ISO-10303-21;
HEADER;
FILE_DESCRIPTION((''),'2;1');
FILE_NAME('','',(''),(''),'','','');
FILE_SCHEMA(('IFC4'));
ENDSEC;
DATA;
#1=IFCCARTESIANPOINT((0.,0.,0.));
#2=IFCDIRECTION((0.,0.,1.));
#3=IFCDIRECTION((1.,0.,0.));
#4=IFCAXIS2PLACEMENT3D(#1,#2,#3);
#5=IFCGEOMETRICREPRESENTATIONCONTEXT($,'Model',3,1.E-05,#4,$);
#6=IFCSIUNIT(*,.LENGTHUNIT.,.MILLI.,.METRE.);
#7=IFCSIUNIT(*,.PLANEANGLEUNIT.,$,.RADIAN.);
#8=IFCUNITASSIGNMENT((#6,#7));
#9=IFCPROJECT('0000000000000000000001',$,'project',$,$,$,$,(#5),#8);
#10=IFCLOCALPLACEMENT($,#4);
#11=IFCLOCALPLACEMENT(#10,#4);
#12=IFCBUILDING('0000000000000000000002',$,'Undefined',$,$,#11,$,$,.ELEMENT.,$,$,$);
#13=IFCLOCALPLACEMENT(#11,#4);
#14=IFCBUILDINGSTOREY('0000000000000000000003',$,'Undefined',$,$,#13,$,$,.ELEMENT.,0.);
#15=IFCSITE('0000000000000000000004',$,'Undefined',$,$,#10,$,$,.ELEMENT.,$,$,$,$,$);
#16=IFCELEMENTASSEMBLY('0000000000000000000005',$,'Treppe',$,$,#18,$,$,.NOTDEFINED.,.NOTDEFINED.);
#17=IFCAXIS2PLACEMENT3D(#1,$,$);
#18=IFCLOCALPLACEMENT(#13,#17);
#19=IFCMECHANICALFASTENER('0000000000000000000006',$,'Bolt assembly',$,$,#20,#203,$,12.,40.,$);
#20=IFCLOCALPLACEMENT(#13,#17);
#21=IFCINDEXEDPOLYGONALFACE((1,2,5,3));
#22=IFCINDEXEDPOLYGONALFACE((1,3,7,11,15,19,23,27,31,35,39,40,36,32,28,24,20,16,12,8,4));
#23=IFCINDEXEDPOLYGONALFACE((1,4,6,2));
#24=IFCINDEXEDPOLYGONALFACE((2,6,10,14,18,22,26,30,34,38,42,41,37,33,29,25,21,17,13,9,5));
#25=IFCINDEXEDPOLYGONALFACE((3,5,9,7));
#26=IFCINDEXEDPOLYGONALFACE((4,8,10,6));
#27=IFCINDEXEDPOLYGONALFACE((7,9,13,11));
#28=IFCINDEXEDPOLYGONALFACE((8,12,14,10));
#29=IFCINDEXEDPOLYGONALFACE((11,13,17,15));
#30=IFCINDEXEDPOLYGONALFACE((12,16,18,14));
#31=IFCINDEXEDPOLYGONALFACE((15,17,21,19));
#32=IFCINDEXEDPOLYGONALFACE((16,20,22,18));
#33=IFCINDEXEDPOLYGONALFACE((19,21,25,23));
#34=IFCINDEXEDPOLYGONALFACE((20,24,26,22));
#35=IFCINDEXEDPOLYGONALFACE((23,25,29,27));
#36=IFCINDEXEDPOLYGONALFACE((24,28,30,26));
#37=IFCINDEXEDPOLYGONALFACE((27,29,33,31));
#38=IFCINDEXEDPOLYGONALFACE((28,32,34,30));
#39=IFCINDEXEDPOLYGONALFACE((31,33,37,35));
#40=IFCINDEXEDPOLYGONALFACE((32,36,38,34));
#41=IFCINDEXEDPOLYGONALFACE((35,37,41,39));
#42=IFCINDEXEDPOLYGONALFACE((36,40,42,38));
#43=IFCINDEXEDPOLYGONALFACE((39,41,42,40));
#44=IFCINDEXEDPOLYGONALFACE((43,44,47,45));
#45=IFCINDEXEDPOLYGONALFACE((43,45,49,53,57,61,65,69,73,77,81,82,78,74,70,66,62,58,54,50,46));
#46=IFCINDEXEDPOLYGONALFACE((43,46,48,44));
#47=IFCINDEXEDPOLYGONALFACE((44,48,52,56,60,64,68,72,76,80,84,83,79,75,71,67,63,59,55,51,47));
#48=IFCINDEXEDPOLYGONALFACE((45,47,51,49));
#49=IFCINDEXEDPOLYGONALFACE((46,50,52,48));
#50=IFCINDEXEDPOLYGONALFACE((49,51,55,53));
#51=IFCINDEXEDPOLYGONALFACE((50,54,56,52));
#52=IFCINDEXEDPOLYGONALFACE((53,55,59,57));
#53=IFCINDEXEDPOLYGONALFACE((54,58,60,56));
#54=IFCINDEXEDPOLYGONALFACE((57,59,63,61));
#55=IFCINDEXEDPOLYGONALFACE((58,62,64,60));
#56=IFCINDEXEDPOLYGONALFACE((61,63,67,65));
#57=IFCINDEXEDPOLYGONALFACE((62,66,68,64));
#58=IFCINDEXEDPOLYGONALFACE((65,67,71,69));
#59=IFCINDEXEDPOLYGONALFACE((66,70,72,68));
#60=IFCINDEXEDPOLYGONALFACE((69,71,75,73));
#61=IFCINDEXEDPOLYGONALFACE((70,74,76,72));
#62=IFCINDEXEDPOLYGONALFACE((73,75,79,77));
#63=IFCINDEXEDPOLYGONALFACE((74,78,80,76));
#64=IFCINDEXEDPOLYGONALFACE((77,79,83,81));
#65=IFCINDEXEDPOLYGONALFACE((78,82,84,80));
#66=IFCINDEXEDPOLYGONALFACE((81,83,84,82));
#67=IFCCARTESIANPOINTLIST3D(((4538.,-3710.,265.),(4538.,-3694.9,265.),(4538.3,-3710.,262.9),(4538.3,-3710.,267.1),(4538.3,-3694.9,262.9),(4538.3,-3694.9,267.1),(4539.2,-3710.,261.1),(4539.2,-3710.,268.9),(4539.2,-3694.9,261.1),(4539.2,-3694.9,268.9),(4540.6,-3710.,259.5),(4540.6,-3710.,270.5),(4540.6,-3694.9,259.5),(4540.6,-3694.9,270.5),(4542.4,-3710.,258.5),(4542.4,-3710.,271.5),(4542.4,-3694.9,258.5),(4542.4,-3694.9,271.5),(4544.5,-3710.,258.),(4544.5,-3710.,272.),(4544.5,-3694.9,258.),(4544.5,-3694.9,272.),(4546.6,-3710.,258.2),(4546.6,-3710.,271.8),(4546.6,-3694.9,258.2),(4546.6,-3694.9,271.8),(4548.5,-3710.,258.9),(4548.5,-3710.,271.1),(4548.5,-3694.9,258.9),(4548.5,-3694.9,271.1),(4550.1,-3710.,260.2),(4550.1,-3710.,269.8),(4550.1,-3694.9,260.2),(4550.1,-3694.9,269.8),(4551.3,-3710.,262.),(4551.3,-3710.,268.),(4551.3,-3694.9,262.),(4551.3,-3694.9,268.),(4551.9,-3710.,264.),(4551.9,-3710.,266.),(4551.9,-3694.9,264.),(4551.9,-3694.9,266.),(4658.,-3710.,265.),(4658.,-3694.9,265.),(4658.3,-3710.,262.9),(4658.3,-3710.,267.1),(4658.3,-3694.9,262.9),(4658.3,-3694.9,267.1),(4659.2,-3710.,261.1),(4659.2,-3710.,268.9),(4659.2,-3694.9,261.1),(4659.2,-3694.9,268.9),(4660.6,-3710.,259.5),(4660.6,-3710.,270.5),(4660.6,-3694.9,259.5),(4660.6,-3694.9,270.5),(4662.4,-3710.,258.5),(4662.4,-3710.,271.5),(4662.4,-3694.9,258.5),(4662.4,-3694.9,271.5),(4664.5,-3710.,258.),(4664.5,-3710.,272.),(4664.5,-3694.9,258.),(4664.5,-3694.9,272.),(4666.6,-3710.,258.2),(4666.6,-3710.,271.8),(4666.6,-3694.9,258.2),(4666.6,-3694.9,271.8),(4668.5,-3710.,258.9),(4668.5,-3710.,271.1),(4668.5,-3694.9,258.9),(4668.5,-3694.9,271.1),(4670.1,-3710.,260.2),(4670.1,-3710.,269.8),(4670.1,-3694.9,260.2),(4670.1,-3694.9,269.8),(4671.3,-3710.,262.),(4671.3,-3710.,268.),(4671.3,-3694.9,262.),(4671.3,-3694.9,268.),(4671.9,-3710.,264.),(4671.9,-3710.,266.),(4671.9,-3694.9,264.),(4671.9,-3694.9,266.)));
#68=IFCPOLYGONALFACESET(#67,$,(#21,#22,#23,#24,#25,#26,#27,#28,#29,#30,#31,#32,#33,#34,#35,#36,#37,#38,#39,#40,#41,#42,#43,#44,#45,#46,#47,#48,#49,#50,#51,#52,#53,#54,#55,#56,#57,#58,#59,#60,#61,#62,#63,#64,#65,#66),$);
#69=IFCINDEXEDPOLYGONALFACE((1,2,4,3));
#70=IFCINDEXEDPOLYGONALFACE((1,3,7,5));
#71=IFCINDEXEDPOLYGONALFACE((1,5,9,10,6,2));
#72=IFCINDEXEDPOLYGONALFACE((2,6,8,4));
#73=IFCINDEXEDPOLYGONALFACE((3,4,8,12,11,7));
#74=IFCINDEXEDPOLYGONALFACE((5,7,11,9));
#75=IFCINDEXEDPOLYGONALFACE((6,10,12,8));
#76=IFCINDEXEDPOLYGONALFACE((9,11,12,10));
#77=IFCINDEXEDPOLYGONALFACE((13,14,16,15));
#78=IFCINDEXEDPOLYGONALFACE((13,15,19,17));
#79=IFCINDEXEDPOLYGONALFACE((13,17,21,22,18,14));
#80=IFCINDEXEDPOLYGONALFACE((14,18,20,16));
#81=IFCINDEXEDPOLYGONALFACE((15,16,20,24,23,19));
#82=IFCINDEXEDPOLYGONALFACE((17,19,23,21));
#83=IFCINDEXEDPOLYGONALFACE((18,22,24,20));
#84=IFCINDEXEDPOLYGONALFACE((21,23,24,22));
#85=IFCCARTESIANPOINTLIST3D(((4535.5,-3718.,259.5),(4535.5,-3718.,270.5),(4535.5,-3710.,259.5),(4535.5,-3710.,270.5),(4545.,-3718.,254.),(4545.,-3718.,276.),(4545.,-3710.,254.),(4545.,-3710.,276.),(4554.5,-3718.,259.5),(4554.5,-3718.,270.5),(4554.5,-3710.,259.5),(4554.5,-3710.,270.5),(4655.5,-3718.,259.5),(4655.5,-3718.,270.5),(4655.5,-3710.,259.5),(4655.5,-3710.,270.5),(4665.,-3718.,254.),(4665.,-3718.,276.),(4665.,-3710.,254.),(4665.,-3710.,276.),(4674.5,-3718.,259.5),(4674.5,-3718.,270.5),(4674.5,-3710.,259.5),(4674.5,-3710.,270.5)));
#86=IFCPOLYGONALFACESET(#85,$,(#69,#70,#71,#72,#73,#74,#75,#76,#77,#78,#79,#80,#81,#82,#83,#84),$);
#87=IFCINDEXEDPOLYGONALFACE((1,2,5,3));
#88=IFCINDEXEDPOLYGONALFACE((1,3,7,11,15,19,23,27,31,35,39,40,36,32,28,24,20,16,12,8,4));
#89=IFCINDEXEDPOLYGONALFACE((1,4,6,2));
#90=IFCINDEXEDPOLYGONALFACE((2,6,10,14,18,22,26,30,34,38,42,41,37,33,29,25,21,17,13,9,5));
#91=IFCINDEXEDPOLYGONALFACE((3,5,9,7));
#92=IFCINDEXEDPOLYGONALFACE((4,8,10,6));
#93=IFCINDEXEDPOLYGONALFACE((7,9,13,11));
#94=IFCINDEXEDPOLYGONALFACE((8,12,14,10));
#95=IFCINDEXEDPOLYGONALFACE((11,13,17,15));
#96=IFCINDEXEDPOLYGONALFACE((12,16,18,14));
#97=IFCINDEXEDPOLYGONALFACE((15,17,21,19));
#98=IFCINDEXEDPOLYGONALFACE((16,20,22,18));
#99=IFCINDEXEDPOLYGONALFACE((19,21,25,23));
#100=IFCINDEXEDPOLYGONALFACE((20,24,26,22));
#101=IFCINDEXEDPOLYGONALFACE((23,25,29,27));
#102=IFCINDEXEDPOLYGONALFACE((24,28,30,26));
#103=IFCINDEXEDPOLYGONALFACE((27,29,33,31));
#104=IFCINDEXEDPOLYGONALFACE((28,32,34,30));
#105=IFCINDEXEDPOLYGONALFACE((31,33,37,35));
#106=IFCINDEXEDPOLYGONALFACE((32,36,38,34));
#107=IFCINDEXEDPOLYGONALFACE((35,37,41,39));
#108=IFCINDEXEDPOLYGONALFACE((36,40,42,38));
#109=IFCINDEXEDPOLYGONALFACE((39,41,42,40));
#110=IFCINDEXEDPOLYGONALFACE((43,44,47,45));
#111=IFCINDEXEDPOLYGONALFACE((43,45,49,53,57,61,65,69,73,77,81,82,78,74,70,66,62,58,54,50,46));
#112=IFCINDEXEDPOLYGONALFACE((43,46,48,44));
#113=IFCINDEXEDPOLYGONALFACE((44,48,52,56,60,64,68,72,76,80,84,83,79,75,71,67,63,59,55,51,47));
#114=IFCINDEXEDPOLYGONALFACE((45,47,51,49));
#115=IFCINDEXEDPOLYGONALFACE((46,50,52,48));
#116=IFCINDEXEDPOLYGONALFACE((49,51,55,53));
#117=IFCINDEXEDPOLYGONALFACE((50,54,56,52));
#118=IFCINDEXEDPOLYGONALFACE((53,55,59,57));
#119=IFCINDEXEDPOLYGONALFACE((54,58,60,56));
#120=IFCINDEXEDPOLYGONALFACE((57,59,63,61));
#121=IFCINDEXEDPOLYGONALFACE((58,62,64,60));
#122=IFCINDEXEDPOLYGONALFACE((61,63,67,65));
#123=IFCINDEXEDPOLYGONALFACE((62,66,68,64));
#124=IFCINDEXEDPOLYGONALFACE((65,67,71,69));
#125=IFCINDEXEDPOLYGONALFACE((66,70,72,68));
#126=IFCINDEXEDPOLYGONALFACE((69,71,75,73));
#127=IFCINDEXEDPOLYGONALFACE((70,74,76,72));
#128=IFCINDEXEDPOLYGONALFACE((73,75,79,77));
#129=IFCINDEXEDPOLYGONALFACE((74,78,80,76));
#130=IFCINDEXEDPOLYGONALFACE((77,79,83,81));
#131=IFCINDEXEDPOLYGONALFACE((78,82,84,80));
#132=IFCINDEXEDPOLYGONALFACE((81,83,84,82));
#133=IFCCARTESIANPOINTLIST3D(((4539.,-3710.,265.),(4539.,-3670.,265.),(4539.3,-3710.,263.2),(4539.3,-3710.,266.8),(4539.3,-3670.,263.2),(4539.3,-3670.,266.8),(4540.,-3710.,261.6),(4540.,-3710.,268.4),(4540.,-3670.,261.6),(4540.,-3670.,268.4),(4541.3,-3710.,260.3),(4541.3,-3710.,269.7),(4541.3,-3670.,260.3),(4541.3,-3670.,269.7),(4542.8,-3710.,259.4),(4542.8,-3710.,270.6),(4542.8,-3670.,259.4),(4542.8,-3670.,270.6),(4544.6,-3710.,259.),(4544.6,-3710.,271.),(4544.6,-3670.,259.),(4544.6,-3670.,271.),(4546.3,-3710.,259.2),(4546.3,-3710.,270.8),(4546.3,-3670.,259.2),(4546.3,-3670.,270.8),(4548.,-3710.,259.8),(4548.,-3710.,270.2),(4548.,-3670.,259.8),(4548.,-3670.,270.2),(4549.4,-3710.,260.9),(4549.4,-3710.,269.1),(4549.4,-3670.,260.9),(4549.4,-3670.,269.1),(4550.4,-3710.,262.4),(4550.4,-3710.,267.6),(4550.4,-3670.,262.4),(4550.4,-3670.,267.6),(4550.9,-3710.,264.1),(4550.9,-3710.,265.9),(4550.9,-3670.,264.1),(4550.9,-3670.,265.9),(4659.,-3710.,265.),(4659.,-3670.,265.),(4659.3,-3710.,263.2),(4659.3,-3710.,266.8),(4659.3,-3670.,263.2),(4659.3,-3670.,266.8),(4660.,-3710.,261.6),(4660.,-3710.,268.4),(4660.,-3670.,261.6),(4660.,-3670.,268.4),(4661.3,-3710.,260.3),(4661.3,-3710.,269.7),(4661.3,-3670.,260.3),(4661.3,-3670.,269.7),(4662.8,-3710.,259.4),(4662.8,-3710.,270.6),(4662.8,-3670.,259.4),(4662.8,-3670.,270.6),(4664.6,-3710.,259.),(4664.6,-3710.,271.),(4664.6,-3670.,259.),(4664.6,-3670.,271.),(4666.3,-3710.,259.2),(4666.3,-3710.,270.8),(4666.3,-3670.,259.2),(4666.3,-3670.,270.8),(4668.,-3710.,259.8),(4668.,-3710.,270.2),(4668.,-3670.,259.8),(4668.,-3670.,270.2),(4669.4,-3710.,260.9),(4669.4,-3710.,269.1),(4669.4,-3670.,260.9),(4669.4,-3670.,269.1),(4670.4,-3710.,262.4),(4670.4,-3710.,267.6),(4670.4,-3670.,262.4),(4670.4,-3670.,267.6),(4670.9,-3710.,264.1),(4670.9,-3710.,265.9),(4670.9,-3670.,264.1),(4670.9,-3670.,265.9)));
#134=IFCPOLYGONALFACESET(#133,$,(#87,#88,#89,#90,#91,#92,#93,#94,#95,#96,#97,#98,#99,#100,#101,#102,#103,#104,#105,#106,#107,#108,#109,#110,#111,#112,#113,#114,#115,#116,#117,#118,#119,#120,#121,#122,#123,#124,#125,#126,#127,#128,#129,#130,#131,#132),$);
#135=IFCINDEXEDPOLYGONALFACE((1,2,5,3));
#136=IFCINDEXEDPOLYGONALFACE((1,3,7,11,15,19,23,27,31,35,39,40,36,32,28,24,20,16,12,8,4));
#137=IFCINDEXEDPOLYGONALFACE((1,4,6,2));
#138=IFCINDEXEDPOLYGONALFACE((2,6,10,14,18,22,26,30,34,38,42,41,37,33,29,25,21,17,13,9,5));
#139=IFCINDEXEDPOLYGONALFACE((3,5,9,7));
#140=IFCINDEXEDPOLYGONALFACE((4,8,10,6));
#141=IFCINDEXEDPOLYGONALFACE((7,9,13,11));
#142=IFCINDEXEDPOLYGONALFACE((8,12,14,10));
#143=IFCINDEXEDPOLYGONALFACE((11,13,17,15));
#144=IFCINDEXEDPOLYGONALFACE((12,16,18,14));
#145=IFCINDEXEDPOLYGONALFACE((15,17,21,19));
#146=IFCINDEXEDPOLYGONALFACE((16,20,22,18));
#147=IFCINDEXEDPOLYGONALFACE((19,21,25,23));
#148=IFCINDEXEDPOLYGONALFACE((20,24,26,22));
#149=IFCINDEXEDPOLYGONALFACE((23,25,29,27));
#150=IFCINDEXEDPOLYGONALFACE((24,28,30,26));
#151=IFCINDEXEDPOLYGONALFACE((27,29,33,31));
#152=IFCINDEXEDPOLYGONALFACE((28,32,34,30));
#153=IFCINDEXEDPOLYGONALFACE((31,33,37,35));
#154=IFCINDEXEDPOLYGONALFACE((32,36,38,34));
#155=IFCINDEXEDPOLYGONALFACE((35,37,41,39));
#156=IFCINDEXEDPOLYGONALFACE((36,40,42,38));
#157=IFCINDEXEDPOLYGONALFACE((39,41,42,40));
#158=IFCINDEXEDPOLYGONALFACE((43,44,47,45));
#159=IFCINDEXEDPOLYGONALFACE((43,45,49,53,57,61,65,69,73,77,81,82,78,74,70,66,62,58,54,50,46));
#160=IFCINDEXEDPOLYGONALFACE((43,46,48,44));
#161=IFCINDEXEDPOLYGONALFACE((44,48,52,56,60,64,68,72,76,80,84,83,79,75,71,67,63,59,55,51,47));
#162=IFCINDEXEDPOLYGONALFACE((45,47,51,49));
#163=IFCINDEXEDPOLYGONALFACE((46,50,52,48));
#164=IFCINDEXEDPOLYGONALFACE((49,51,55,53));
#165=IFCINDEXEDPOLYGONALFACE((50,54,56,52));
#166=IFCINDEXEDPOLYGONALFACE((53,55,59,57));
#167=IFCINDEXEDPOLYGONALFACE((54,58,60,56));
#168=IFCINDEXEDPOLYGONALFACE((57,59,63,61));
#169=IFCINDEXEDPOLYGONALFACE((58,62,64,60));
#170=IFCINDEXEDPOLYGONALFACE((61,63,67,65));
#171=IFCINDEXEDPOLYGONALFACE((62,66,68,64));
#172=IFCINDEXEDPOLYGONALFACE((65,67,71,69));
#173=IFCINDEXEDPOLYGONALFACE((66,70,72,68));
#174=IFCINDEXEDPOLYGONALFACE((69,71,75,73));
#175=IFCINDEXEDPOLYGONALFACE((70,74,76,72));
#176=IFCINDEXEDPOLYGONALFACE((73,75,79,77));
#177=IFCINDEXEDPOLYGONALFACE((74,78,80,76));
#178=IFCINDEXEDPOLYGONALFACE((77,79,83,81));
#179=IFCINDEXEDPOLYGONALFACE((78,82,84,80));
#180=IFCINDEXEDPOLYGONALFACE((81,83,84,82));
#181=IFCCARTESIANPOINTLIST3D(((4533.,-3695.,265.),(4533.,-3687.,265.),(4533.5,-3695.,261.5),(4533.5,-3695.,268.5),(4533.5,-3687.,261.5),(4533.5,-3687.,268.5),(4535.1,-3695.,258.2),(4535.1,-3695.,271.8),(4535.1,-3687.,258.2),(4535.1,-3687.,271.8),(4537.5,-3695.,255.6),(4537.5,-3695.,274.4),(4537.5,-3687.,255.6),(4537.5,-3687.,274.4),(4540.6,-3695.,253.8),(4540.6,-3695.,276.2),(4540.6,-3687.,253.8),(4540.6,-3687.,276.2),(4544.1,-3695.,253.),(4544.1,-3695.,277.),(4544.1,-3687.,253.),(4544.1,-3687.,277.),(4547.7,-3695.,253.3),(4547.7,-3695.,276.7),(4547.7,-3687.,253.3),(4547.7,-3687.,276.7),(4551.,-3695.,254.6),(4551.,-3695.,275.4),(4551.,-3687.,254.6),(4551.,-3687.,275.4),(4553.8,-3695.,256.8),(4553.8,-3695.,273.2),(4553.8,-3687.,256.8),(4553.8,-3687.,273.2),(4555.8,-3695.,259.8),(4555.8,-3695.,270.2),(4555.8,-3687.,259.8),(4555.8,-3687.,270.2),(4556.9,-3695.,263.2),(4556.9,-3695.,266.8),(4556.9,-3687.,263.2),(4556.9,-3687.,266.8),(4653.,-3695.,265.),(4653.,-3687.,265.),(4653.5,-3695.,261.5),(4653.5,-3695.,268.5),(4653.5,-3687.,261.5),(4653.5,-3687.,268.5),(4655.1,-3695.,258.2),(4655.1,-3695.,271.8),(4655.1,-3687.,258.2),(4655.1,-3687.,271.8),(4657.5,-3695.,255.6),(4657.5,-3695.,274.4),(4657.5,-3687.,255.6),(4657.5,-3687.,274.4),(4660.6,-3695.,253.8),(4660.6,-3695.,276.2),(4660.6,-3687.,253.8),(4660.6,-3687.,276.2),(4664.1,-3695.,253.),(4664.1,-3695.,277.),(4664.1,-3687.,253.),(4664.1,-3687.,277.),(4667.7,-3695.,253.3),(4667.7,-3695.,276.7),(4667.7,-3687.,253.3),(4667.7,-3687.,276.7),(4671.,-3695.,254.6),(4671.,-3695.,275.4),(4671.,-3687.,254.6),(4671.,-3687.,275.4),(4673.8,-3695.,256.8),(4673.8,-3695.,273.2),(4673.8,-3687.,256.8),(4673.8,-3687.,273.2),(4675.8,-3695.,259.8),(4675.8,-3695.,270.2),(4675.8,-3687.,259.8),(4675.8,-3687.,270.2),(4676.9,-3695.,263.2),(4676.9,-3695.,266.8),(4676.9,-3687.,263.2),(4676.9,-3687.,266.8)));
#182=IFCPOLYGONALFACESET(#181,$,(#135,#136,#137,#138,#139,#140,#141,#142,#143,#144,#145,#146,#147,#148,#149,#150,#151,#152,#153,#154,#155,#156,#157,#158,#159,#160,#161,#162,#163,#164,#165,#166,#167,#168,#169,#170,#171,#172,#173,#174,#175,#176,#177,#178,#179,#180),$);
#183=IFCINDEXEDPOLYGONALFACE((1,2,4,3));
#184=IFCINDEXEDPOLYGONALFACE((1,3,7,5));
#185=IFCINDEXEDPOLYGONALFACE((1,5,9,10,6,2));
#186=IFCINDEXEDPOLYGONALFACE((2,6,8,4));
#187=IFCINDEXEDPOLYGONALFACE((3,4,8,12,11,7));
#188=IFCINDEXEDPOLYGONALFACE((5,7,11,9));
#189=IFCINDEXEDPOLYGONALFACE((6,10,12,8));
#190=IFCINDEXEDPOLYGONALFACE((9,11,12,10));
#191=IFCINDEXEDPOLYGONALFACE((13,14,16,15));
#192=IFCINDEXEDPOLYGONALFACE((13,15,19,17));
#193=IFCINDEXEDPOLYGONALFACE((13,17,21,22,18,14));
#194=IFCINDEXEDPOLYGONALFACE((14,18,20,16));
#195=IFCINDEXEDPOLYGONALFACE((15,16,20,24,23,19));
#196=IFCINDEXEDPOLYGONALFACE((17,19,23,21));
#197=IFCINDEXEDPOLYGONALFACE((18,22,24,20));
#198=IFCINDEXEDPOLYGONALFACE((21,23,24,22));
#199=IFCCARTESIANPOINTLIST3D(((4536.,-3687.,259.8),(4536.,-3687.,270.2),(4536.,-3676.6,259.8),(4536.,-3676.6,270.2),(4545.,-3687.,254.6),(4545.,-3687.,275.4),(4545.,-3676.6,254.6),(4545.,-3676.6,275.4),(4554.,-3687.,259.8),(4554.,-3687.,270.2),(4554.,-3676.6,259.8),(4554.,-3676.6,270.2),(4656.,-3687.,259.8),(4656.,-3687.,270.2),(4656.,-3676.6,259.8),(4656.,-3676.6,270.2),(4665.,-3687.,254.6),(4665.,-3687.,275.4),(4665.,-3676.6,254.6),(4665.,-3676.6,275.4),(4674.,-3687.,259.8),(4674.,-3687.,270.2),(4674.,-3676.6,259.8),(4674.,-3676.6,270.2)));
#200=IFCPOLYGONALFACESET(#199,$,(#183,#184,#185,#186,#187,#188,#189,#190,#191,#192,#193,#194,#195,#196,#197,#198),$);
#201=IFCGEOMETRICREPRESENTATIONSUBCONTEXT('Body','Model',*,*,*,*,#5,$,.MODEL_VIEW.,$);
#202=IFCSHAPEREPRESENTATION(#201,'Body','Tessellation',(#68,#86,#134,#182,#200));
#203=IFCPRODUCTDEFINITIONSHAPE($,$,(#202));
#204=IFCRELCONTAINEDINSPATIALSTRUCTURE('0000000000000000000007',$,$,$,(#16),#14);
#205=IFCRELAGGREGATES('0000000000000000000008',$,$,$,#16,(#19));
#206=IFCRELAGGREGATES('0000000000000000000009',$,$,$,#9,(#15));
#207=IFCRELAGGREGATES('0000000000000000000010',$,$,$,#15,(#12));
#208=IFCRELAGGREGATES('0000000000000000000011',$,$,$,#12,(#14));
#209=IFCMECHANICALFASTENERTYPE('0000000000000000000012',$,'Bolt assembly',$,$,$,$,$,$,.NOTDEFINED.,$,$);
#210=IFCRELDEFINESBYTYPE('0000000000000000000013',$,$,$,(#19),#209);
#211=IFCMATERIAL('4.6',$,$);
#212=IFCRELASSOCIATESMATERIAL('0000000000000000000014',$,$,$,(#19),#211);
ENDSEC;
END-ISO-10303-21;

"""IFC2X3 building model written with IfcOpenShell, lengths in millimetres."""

from ifc_helpers import new_model, si_unit, frame, origin_with_axes, origin_2d_with_axis, place, context, subcontext, project, spatial, polyline, circle, outline, extrude, source, transform, mapped, material, type_object, element, aggregate, save


model = new_model("IFC2X3")

# Units and contexts
model_context = context("Model", 3, precision=1e-05, world=origin_with_axes())
body_context = subcontext(model_context, "Body", "Model", "MODEL_VIEW")
ifc_project = project(units=[si_unit("LENGTHUNIT", "METRE", prefix="MILLI"), si_unit("PLANEANGLEUNIT", "RADIAN")], contexts=[model_context])

# Site, building, storey
site_placement = place(None, origin_with_axes())
site = spatial("IfcSite", under=ifc_project, at=site_placement, Name="Undefined", CompositionType="ELEMENT")
building_placement = place(site_placement, origin_with_axes())
building = spatial("IfcBuilding", under=site, at=building_placement, Name="Undefined", CompositionType="ELEMENT")
storey_placement = place(building_placement, origin_with_axes())
storey = spatial("IfcBuildingStorey", under=building, at=storey_placement, Name="Undefined", CompositionType="ELEMENT", Elevation=0.0)

# Element assembly
assembly_1_placement = place(storey_placement, origin_with_axes())
assembly_1 = element("IfcElementAssembly", 1, at=assembly_1_placement, inside=storey, Name="Treppe", AssemblyPlace="NOTDEFINED", PredefinedType="NOTDEFINED")

# Mechanical fastener
ifc_material_1 = material(Name="4.6")
mechanical_fastener_type = type_object("IfcMechanicalFastenerType", Name="Bolt assembly")
shared_shape_1 = source(origin_with_axes(), body_context, "Body", "SweptSolid", [
    extrude(circle(Radius=7.0, at=origin_2d_with_axis()), frame((0.0, 0.0, 0.0), z_axis=(0.0, 1.0, 0.0), x_axis=(1.0, 0.0, 0.0)), (0.0, 0.0, 1.0), 15.1),
    extrude(outline(polyline([(9.5, -5.5), (9.5, 5.5), (0.0, 11.0), (-9.5, 5.5), (-9.5, -5.5), (0.0, -11.0), (9.5, -5.5)])), frame((0.0, -8.0, 0.0), z_axis=(0.0, 1.0, 0.0), x_axis=(1.0, 0.0, 0.0)), (0.0, 0.0, 1.0), 8.0),
    extrude(circle(Radius=6.0, at=origin_2d_with_axis()), frame((0.0, 0.0, 0.0), z_axis=(0.0, 1.0, 0.0), x_axis=(1.0, 0.0, 0.0)), (0.0, 0.0, 1.0), 40.0),
    extrude(circle(Radius=12.0, at=origin_2d_with_axis()), frame((0.0, 15.0, 0.0), z_axis=(0.0, 1.0, 0.0), x_axis=(1.0, 0.0, 0.0)), (0.0, 0.0, 1.0), 8.0),
    extrude(outline(polyline([(9.0, -5.2), (9.0, 5.2), (0.0, 10.4), (-9.0, 5.2), (-9.0, -5.2), (0.0, -10.4), (9.0, -5.2)])), frame((0.0, 23.0, 0.0), z_axis=(0.0, 1.0, 0.0), x_axis=(1.0, 0.0, 0.0)), (0.0, 0.0, 1.0), 10.4),
])
mechanical_fastener_1_placement = place(assembly_1_placement, frame((4665.0, -3710.0, 265.0), z_axis=(0.0, 0.0, -1.0), x_axis=(-1.0, 0.0, 0.0)))
mechanical_fastener_1 = element("IfcMechanicalFastener", 2, at=mechanical_fastener_1_placement, type_object=mechanical_fastener_type, material=ifc_material_1, Name="Bolt assembly", NominalDiameter=12.0, NominalLength=40.0, context=body_context, shape_type="MappedRepresentation", body=[
    mapped(shared_shape_1, transform((0.0, 0.0, 0.0))),
    mapped(shared_shape_1, transform((120.0, 0.0, 0.0))),
])
aggregate(assembly_1, [mechanical_fastener_1])

save(model, "model.ifc")
